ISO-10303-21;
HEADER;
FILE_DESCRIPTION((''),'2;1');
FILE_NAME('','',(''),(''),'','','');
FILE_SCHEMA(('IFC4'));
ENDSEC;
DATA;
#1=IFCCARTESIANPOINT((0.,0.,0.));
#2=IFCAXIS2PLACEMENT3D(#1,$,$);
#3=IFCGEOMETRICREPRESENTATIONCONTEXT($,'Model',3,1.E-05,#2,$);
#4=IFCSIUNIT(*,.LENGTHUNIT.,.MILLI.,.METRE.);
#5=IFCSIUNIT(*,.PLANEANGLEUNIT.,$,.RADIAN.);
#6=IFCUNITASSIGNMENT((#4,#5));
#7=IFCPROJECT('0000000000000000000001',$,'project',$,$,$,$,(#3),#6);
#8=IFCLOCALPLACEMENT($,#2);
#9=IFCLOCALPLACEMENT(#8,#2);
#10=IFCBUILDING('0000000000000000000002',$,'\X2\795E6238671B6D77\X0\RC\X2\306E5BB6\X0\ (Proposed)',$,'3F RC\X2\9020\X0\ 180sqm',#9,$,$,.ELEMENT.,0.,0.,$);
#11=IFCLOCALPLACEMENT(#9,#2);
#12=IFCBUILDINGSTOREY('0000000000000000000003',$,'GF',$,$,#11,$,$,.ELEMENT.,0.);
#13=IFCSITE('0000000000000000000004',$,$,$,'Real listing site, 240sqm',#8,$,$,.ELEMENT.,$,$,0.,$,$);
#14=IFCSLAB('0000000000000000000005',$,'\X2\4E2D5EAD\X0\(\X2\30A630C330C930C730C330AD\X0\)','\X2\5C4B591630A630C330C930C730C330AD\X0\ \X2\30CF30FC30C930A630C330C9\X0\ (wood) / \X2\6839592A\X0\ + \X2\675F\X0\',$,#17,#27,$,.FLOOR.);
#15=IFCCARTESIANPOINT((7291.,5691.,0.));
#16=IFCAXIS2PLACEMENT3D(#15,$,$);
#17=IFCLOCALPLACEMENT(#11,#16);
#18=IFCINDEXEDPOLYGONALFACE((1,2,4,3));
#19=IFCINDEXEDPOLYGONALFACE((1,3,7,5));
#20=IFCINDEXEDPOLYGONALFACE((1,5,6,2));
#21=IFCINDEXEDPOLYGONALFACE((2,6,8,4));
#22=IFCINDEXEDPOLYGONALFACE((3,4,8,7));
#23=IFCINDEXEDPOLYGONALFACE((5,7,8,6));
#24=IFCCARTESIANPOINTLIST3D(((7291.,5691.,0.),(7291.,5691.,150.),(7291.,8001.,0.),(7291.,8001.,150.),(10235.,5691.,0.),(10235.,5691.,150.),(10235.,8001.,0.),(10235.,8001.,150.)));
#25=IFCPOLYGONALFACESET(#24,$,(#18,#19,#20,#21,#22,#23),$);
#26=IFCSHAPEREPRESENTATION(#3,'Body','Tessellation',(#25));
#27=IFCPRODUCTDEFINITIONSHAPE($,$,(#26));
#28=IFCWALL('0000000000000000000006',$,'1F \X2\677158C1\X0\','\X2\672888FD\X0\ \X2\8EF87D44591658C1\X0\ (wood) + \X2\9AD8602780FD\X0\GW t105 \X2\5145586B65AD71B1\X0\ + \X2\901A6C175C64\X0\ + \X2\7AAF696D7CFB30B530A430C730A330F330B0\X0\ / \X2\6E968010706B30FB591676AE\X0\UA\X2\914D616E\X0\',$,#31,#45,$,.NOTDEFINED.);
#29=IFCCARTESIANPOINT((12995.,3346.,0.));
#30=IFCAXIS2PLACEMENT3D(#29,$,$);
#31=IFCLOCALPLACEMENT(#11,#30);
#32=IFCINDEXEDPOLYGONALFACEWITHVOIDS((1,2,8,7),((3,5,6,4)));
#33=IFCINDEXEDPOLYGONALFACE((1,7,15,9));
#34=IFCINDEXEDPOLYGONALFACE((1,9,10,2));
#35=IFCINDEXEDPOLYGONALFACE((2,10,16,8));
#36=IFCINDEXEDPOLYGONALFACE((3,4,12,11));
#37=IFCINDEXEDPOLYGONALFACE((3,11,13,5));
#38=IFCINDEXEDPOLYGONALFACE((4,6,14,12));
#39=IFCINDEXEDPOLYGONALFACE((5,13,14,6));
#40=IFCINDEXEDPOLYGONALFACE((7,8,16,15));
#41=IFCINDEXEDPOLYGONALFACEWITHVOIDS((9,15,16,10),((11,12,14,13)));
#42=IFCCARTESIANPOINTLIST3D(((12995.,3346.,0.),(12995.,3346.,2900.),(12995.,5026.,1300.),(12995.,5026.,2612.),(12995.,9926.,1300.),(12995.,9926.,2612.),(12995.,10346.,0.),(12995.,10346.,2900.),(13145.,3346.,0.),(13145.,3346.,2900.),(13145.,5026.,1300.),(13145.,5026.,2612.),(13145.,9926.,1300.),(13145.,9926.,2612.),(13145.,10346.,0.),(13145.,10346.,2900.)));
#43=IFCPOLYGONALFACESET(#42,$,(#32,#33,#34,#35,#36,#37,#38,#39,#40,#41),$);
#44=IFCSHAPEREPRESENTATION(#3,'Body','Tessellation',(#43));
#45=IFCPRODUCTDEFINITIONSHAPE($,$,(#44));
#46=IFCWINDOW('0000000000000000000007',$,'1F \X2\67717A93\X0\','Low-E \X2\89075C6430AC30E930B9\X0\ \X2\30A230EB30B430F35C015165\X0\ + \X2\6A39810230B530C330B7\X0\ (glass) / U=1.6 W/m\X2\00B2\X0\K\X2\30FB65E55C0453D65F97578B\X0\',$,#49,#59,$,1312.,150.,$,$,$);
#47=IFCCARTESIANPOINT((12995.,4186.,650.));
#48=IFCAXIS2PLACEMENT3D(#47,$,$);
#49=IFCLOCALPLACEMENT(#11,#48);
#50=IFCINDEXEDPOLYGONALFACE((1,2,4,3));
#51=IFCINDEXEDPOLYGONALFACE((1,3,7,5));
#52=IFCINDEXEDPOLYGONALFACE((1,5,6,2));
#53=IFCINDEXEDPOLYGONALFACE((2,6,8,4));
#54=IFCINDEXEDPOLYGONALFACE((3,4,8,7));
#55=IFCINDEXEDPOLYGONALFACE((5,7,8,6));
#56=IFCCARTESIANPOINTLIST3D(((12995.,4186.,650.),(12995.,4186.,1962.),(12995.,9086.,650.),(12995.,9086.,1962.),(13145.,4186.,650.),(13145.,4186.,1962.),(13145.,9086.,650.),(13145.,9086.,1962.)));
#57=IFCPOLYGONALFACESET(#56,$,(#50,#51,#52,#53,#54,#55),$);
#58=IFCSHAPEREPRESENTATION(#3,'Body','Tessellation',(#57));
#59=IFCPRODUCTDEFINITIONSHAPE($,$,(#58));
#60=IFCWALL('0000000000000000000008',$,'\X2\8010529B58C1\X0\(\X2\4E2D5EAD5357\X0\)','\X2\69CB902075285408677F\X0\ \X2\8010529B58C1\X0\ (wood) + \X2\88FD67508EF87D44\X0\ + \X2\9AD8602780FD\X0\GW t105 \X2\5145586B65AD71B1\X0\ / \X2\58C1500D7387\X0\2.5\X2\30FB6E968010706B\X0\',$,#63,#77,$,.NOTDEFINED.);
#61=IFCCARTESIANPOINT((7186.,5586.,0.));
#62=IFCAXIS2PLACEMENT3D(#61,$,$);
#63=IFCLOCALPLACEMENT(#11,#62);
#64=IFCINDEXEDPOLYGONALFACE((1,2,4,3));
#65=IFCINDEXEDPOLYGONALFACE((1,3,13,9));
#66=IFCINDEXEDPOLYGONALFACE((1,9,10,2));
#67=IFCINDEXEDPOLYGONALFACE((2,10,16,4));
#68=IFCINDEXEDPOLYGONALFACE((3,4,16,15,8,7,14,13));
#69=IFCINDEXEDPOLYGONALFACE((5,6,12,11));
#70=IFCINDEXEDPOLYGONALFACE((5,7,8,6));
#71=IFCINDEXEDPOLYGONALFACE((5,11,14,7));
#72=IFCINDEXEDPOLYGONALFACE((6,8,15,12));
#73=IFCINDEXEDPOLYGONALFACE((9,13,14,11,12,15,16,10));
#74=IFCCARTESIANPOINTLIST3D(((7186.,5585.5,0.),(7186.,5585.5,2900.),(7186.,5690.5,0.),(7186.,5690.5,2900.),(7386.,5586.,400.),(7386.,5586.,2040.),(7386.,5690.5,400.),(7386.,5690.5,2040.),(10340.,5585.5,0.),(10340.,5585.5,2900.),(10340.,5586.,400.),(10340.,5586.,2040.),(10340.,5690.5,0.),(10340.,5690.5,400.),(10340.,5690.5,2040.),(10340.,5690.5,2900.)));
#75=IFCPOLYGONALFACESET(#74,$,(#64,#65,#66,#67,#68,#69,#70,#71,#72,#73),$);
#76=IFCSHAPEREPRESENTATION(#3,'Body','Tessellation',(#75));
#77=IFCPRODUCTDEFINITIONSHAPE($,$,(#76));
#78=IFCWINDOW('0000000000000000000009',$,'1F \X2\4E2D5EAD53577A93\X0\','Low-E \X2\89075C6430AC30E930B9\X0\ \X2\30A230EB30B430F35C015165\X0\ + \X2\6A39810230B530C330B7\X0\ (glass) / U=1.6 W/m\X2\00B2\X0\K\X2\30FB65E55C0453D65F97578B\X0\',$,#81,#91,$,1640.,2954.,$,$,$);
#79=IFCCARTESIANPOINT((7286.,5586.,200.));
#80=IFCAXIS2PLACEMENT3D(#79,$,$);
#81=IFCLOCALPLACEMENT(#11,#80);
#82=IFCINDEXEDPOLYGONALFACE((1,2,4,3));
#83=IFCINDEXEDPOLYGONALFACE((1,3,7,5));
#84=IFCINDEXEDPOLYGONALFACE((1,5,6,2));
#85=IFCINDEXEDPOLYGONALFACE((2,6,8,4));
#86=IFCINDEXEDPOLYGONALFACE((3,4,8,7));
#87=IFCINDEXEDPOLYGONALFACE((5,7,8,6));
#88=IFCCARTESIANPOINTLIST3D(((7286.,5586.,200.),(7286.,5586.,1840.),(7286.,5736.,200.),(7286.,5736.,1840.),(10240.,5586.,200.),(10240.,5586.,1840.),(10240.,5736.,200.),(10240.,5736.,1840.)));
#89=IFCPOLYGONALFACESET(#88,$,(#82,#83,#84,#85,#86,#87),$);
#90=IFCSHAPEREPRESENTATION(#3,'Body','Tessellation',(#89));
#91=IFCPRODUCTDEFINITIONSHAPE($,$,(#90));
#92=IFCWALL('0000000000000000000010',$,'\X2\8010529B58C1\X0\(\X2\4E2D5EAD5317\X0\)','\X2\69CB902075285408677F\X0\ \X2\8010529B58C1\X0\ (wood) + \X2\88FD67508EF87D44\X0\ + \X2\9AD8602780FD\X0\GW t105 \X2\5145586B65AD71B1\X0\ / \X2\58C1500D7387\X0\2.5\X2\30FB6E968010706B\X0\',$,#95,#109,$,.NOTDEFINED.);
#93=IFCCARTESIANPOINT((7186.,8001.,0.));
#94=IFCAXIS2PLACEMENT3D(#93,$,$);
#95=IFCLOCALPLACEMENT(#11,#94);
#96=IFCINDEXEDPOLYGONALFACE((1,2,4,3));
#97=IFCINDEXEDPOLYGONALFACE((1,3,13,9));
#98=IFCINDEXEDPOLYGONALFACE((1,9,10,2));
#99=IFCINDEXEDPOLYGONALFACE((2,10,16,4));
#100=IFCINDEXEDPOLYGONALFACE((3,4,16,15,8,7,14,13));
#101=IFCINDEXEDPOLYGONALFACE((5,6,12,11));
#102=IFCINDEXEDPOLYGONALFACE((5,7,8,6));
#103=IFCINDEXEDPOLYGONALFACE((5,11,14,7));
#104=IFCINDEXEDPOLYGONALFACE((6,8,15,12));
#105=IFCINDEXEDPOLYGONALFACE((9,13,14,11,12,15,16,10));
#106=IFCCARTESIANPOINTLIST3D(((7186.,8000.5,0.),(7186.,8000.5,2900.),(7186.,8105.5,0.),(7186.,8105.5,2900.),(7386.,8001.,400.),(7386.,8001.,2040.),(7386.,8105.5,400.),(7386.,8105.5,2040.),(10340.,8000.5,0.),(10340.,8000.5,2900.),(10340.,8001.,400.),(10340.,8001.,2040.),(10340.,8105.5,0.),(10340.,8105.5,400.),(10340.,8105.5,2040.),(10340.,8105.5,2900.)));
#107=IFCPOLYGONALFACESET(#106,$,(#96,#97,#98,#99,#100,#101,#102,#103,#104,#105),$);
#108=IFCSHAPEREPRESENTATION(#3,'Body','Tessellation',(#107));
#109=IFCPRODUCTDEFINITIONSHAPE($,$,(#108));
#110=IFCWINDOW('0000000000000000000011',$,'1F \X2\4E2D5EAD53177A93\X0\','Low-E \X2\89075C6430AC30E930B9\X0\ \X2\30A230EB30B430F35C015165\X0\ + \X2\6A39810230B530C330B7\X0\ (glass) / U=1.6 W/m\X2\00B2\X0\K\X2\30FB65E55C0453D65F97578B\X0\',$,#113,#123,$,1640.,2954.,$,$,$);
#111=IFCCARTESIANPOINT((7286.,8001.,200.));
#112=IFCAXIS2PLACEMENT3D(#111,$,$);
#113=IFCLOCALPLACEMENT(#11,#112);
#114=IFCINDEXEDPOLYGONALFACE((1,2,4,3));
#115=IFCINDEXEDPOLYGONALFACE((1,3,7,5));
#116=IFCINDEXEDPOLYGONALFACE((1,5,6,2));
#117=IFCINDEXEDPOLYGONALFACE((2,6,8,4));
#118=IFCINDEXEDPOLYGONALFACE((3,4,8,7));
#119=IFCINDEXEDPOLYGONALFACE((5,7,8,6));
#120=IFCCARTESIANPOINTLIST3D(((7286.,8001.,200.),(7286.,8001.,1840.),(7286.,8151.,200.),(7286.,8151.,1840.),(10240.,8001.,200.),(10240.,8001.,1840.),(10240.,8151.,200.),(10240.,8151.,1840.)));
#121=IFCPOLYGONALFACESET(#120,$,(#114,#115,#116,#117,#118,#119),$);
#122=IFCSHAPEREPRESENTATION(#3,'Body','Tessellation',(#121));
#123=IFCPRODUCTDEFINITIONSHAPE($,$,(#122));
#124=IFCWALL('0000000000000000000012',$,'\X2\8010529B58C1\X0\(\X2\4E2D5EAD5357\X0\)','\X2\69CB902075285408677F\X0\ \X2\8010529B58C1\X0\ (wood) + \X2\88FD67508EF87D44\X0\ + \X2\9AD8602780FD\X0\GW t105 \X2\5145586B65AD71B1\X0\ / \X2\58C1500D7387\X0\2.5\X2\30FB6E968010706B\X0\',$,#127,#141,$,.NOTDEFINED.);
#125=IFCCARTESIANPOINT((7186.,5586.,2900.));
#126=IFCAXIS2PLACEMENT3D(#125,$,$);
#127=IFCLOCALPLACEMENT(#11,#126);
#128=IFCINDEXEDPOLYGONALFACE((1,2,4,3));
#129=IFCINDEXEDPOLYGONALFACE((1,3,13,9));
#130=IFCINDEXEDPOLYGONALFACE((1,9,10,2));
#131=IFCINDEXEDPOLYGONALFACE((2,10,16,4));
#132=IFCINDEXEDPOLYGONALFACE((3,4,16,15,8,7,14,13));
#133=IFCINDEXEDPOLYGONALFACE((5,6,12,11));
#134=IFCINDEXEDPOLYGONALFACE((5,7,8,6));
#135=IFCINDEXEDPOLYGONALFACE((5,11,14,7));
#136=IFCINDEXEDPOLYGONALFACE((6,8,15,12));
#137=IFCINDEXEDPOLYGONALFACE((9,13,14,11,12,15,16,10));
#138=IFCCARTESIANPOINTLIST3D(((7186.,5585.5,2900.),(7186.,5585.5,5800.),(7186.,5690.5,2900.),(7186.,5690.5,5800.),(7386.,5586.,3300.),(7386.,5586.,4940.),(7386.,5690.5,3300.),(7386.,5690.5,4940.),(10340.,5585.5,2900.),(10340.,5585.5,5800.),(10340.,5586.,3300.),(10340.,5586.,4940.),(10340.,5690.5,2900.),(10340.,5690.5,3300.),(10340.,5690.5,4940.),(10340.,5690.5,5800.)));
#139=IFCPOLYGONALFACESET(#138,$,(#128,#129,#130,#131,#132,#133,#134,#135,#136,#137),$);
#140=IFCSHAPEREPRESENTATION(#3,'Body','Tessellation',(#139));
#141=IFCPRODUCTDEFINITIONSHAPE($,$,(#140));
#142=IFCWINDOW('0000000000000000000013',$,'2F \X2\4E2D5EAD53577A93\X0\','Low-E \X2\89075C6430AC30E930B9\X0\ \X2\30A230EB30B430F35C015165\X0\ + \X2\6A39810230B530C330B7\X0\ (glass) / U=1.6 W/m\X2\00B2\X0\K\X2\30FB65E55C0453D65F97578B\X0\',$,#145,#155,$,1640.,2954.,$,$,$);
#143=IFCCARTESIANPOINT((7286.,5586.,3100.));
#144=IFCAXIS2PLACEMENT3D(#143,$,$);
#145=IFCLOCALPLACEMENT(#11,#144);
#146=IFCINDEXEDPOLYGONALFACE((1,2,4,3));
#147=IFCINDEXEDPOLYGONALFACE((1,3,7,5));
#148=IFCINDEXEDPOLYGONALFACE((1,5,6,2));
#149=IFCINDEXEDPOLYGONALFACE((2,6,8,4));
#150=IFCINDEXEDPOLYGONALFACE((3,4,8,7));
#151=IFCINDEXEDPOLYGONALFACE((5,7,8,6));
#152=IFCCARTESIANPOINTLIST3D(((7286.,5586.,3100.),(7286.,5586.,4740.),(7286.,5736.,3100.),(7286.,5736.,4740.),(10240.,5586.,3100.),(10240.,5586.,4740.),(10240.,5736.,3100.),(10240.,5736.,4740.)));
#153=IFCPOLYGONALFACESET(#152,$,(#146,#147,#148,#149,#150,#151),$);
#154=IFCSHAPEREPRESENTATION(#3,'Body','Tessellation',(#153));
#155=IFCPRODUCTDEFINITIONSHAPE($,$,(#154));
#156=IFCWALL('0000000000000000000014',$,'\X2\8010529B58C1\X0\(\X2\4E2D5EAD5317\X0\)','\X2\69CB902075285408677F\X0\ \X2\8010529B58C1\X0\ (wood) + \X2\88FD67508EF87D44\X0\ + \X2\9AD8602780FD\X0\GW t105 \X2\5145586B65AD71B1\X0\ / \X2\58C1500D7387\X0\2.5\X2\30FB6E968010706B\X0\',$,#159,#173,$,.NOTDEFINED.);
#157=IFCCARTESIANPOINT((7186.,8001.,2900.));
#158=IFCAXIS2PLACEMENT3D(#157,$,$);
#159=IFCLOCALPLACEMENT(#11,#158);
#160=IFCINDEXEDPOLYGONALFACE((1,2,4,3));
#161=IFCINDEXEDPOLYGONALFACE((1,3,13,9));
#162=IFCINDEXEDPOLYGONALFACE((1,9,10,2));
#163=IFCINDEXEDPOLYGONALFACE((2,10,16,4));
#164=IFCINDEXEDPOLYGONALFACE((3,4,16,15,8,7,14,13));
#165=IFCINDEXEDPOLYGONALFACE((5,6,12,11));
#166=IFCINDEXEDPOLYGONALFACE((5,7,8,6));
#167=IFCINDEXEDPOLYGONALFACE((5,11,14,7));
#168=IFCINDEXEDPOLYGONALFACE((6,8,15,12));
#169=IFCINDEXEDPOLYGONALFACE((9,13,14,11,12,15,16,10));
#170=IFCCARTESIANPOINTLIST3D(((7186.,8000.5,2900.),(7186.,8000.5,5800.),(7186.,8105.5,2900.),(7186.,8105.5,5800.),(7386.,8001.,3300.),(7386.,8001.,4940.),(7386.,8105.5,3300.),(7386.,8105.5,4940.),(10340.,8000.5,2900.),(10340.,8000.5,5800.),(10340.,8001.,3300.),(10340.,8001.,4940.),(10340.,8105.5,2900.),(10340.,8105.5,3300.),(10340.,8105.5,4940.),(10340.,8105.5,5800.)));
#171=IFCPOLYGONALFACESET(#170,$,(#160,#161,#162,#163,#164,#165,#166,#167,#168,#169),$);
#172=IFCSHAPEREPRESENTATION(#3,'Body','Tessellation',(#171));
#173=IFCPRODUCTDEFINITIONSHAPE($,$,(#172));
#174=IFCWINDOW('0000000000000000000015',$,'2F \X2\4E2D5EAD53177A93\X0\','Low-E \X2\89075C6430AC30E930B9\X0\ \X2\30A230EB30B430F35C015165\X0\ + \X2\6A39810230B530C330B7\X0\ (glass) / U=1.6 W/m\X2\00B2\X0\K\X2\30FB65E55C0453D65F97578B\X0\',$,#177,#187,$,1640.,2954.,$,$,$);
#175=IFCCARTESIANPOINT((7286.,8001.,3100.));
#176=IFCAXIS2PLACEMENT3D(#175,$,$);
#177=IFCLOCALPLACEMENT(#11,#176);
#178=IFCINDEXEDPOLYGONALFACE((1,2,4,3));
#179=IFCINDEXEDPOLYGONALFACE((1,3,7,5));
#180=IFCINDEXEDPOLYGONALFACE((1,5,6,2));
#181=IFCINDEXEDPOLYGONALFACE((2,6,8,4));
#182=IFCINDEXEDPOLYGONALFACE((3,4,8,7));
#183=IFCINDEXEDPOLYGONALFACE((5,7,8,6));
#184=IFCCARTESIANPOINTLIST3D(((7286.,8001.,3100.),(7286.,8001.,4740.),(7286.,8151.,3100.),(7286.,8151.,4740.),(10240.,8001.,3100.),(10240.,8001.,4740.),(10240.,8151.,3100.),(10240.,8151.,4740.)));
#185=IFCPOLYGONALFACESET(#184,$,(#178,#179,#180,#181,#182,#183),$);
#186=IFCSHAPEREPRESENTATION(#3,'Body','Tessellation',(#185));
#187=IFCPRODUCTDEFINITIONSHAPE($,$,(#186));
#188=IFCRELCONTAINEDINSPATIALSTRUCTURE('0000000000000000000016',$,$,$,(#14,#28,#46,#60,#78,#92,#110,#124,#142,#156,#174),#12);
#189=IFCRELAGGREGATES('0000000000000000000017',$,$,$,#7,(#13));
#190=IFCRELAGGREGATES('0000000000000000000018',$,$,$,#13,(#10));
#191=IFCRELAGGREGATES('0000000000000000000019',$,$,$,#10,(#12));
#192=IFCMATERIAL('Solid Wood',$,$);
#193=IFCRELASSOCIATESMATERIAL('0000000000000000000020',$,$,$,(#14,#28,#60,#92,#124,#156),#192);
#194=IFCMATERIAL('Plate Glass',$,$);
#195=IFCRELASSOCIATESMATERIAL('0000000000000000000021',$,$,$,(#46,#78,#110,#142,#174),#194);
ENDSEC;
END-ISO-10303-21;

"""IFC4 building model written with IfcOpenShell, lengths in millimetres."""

from ifc_helpers import new_model, si_unit, frame, frame_2d, origin, place, context, project, spatial, rectangle, extrude, material, element, fill, save


model = new_model("IFC4")

# Units and contexts
model_context = context("Model", 3, precision=1e-05, world=origin())
ifc_project = project(units=[si_unit("LENGTHUNIT", "METRE", prefix="MILLI"), si_unit("PLANEANGLEUNIT", "RADIAN")], contexts=[model_context])

# Site, building, storey
site_placement = place(None, origin())
site = spatial("IfcSite", under=ifc_project, at=site_placement, ObjectType="Real listing site, 240sqm", CompositionType="ELEMENT", RefElevation=0.0)
building_placement = place(site_placement, origin())
building = spatial("IfcBuilding", under=site, at=building_placement, Name="神戸望海RCの家 (Proposed)", ObjectType="3F RC造 180sqm", CompositionType="ELEMENT", ElevationOfRefHeight=0.0, ElevationOfTerrain=0.0)
storey_placement = place(building_placement, origin())
storey = spatial("IfcBuildingStorey", under=building, at=storey_placement, Name="GF", CompositionType="ELEMENT", Elevation=0.0)

# Slab
ifc_material_1 = material(Name="Solid Wood")
slab_1_placement = place(storey_placement, frame((7291.0, 5691.0, 0.0)))
element("IfcSlab", 1, at=slab_1_placement, inside=storey, material=ifc_material_1, Name="中庭(ウッドデッキ)", Description="屋外ウッドデッキ ハードウッド (wood) / 根太 + 束", PredefinedType="FLOOR", context=model_context, shape_type="SweptSolid", body=[
    extrude(rectangle(XDim=2944.0, YDim=2310.0, at=frame_2d((1472.0, 1155.0))), frame((7291.0, 5691.0, 0.0)), (0.0, 0.0, 1.0), 150.0),
])

# Walls, openings, windows
wall_1_placement = place(storey_placement, frame((12995.0, 3346.0, 0.0)))
wall_1 = element("IfcWall", 2, at=wall_1_placement, inside=storey, material=ifc_material_1, Name="1F 東壁", Description="木製 軸組外壁 (wood) + 高性能GW t105 充填断熱 + 通気層 + 窯業系サイディング / 準耐火・外皮UA配慮", PredefinedType="NOTDEFINED", context=model_context, shape_type="SweptSolid", body=[
    extrude(rectangle(XDim=150.0, YDim=7000.0, at=frame_2d((75.0, 3500.0))), frame((12995.0, 3346.0, 0.0)), (0.0, 0.0, 1.0), 2900.0),
])
opening_1_placement = place(storey_placement, frame((12995.0, 4186.0, 650.0)))
opening_1 = element("IfcOpeningElement", 3, at=opening_1_placement, cuts=wall_1, PredefinedType="NOTDEFINED", context=model_context, shape_type="SweptSolid", body=[
    extrude(rectangle(XDim=150.0, YDim=4900.0, at=frame_2d((75.0, 2450.0))), frame((12995.0, 4186.0, 650.0)), (0.0, 0.0, 1.0), 1312.0),
])
ifc_material_2 = material(Name="Plate Glass")
window_1_placement = place(storey_placement, frame((12995.0, 4186.0, 650.0)))
window_1 = element("IfcWindow", 4, at=window_1_placement, inside=storey, material=ifc_material_2, Name="1F 東窓", Description="Low-E 複層ガラス アルゴン封入 + 樹脂サッシ (glass) / U=1.6 W/m²K・日射取得型", OverallHeight=1312.0, OverallWidth=150.0, context=model_context, shape_type="SweptSolid", body=[
    extrude(rectangle(XDim=150.0, YDim=4900.0, at=frame_2d((75.0, 2450.0))), frame((12995.0, 4186.0, 650.0)), (0.0, 0.0, 1.0), 1312.0),
])
fill(opening_1, window_1)
wall_2_placement = place(storey_placement, frame((7186.0, 5586.0, 0.0)))
wall_2 = element("IfcWall", 5, at=wall_2_placement, inside=storey, material=ifc_material_1, Name="耐力壁(中庭南)", Description="構造用合板 耐力壁 (wood) + 製材軸組 + 高性能GW t105 充填断熱 / 壁倍率2.5・準耐火", PredefinedType="NOTDEFINED", context=model_context, shape_type="SweptSolid", body=[
    extrude(rectangle(XDim=3154.0, YDim=105.0, at=frame_2d((1577.0, 52.0))), frame((7186.0, 5586.0, 0.0)), (0.0, 0.0, 1.0), 2900.0),
])
opening_2_placement = place(storey_placement, frame((7286.0, 5586.0, 200.0)))
opening_2 = element("IfcOpeningElement", 6, at=opening_2_placement, cuts=wall_2, PredefinedType="NOTDEFINED", context=model_context, shape_type="SweptSolid", body=[
    extrude(rectangle(XDim=2954.0, YDim=150.0, at=frame_2d((1477.0, 75.0))), frame((7286.0, 5586.0, 200.0)), (0.0, 0.0, 1.0), 1640.0),
])
window_2_placement = place(storey_placement, frame((7286.0, 5586.0, 200.0)))
window_2 = element("IfcWindow", 7, at=window_2_placement, inside=storey, material=ifc_material_2, Name="1F 中庭南窓", Description="Low-E 複層ガラス アルゴン封入 + 樹脂サッシ (glass) / U=1.6 W/m²K・日射取得型", OverallHeight=1640.0, OverallWidth=2954.0, context=model_context, shape_type="SweptSolid", body=[
    extrude(rectangle(XDim=2954.0, YDim=150.0, at=frame_2d((1477.0, 75.0))), frame((7286.0, 5586.0, 200.0)), (0.0, 0.0, 1.0), 1640.0),
])
fill(opening_2, window_2)
wall_3_placement = place(storey_placement, frame((7186.0, 8001.0, 0.0)))
wall_3 = element("IfcWall", 8, at=wall_3_placement, inside=storey, material=ifc_material_1, Name="耐力壁(中庭北)", Description="構造用合板 耐力壁 (wood) + 製材軸組 + 高性能GW t105 充填断熱 / 壁倍率2.5・準耐火", PredefinedType="NOTDEFINED", context=model_context, shape_type="SweptSolid", body=[
    extrude(rectangle(XDim=3154.0, YDim=105.0, at=frame_2d((1577.0, 52.0))), frame((7186.0, 8001.0, 0.0)), (0.0, 0.0, 1.0), 2900.0),
])
opening_3_placement = place(storey_placement, frame((7286.0, 8001.0, 200.0)))
opening_3 = element("IfcOpeningElement", 9, at=opening_3_placement, cuts=wall_3, PredefinedType="NOTDEFINED", context=model_context, shape_type="SweptSolid", body=[
    extrude(rectangle(XDim=2954.0, YDim=150.0, at=frame_2d((1477.0, 75.0))), frame((7286.0, 8001.0, 200.0)), (0.0, 0.0, 1.0), 1640.0),
])
window_3_placement = place(storey_placement, frame((7286.0, 8001.0, 200.0)))
window_3 = element("IfcWindow", 10, at=window_3_placement, inside=storey, material=ifc_material_2, Name="1F 中庭北窓", Description="Low-E 複層ガラス アルゴン封入 + 樹脂サッシ (glass) / U=1.6 W/m²K・日射取得型", OverallHeight=1640.0, OverallWidth=2954.0, context=model_context, shape_type="SweptSolid", body=[
    extrude(rectangle(XDim=2954.0, YDim=150.0, at=frame_2d((1477.0, 75.0))), frame((7286.0, 8001.0, 200.0)), (0.0, 0.0, 1.0), 1640.0),
])
fill(opening_3, window_3)

# Walls, openings, windows
wall_4_placement = place(storey_placement, frame((7186.0, 5586.0, 2900.0)))
wall_4 = element("IfcWall", 11, at=wall_4_placement, inside=storey, material=ifc_material_1, Name="耐力壁(中庭南)", Description="構造用合板 耐力壁 (wood) + 製材軸組 + 高性能GW t105 充填断熱 / 壁倍率2.5・準耐火", PredefinedType="NOTDEFINED", context=model_context, shape_type="SweptSolid", body=[
    extrude(rectangle(XDim=3154.0, YDim=105.0, at=frame_2d((1577.0, 52.0))), frame((7186.0, 5586.0, 2900.0)), (0.0, 0.0, 1.0), 2900.0),
])
opening_4_placement = place(storey_placement, frame((7286.0, 5586.0, 3100.0)))
opening_4 = element("IfcOpeningElement", 12, at=opening_4_placement, cuts=wall_4, PredefinedType="NOTDEFINED", context=model_context, shape_type="SweptSolid", body=[
    extrude(rectangle(XDim=2954.0, YDim=150.0, at=frame_2d((1477.0, 75.0))), frame((7286.0, 5586.0, 3100.0)), (0.0, 0.0, 1.0), 1640.0),
])
window_4_placement = place(storey_placement, frame((7286.0, 5586.0, 3100.0)))
window_4 = element("IfcWindow", 13, at=window_4_placement, inside=storey, material=ifc_material_2, Name="2F 中庭南窓", Description="Low-E 複層ガラス アルゴン封入 + 樹脂サッシ (glass) / U=1.6 W/m²K・日射取得型", OverallHeight=1640.0, OverallWidth=2954.0, context=model_context, shape_type="SweptSolid", body=[
    extrude(rectangle(XDim=2954.0, YDim=150.0, at=frame_2d((1477.0, 75.0))), frame((7286.0, 5586.0, 3100.0)), (0.0, 0.0, 1.0), 1640.0),
])
fill(opening_4, window_4)
wall_5_placement = place(storey_placement, frame((7186.0, 8001.0, 2900.0)))
wall_5 = element("IfcWall", 14, at=wall_5_placement, inside=storey, material=ifc_material_1, Name="耐力壁(中庭北)", Description="構造用合板 耐力壁 (wood) + 製材軸組 + 高性能GW t105 充填断熱 / 壁倍率2.5・準耐火", PredefinedType="NOTDEFINED", context=model_context, shape_type="SweptSolid", body=[
    extrude(rectangle(XDim=3154.0, YDim=105.0, at=frame_2d((1577.0, 52.0))), frame((7186.0, 8001.0, 2900.0)), (0.0, 0.0, 1.0), 2900.0),
])
opening_5_placement = place(storey_placement, frame((7286.0, 8001.0, 3100.0)))
opening_5 = element("IfcOpeningElement", 15, at=opening_5_placement, cuts=wall_5, PredefinedType="NOTDEFINED", context=model_context, shape_type="SweptSolid", body=[
    extrude(rectangle(XDim=2954.0, YDim=150.0, at=frame_2d((1477.0, 75.0))), frame((7286.0, 8001.0, 3100.0)), (0.0, 0.0, 1.0), 1640.0),
])
window_5_placement = place(storey_placement, frame((7286.0, 8001.0, 3100.0)))
window_5 = element("IfcWindow", 16, at=window_5_placement, inside=storey, material=ifc_material_2, Name="2F 中庭北窓", Description="Low-E 複層ガラス アルゴン封入 + 樹脂サッシ (glass) / U=1.6 W/m²K・日射取得型", OverallHeight=1640.0, OverallWidth=2954.0, context=model_context, shape_type="SweptSolid", body=[
    extrude(rectangle(XDim=2954.0, YDim=150.0, at=frame_2d((1477.0, 75.0))), frame((7286.0, 8001.0, 3100.0)), (0.0, 0.0, 1.0), 1640.0),
])
fill(opening_5, window_5)

save(model, "model.ifc")
